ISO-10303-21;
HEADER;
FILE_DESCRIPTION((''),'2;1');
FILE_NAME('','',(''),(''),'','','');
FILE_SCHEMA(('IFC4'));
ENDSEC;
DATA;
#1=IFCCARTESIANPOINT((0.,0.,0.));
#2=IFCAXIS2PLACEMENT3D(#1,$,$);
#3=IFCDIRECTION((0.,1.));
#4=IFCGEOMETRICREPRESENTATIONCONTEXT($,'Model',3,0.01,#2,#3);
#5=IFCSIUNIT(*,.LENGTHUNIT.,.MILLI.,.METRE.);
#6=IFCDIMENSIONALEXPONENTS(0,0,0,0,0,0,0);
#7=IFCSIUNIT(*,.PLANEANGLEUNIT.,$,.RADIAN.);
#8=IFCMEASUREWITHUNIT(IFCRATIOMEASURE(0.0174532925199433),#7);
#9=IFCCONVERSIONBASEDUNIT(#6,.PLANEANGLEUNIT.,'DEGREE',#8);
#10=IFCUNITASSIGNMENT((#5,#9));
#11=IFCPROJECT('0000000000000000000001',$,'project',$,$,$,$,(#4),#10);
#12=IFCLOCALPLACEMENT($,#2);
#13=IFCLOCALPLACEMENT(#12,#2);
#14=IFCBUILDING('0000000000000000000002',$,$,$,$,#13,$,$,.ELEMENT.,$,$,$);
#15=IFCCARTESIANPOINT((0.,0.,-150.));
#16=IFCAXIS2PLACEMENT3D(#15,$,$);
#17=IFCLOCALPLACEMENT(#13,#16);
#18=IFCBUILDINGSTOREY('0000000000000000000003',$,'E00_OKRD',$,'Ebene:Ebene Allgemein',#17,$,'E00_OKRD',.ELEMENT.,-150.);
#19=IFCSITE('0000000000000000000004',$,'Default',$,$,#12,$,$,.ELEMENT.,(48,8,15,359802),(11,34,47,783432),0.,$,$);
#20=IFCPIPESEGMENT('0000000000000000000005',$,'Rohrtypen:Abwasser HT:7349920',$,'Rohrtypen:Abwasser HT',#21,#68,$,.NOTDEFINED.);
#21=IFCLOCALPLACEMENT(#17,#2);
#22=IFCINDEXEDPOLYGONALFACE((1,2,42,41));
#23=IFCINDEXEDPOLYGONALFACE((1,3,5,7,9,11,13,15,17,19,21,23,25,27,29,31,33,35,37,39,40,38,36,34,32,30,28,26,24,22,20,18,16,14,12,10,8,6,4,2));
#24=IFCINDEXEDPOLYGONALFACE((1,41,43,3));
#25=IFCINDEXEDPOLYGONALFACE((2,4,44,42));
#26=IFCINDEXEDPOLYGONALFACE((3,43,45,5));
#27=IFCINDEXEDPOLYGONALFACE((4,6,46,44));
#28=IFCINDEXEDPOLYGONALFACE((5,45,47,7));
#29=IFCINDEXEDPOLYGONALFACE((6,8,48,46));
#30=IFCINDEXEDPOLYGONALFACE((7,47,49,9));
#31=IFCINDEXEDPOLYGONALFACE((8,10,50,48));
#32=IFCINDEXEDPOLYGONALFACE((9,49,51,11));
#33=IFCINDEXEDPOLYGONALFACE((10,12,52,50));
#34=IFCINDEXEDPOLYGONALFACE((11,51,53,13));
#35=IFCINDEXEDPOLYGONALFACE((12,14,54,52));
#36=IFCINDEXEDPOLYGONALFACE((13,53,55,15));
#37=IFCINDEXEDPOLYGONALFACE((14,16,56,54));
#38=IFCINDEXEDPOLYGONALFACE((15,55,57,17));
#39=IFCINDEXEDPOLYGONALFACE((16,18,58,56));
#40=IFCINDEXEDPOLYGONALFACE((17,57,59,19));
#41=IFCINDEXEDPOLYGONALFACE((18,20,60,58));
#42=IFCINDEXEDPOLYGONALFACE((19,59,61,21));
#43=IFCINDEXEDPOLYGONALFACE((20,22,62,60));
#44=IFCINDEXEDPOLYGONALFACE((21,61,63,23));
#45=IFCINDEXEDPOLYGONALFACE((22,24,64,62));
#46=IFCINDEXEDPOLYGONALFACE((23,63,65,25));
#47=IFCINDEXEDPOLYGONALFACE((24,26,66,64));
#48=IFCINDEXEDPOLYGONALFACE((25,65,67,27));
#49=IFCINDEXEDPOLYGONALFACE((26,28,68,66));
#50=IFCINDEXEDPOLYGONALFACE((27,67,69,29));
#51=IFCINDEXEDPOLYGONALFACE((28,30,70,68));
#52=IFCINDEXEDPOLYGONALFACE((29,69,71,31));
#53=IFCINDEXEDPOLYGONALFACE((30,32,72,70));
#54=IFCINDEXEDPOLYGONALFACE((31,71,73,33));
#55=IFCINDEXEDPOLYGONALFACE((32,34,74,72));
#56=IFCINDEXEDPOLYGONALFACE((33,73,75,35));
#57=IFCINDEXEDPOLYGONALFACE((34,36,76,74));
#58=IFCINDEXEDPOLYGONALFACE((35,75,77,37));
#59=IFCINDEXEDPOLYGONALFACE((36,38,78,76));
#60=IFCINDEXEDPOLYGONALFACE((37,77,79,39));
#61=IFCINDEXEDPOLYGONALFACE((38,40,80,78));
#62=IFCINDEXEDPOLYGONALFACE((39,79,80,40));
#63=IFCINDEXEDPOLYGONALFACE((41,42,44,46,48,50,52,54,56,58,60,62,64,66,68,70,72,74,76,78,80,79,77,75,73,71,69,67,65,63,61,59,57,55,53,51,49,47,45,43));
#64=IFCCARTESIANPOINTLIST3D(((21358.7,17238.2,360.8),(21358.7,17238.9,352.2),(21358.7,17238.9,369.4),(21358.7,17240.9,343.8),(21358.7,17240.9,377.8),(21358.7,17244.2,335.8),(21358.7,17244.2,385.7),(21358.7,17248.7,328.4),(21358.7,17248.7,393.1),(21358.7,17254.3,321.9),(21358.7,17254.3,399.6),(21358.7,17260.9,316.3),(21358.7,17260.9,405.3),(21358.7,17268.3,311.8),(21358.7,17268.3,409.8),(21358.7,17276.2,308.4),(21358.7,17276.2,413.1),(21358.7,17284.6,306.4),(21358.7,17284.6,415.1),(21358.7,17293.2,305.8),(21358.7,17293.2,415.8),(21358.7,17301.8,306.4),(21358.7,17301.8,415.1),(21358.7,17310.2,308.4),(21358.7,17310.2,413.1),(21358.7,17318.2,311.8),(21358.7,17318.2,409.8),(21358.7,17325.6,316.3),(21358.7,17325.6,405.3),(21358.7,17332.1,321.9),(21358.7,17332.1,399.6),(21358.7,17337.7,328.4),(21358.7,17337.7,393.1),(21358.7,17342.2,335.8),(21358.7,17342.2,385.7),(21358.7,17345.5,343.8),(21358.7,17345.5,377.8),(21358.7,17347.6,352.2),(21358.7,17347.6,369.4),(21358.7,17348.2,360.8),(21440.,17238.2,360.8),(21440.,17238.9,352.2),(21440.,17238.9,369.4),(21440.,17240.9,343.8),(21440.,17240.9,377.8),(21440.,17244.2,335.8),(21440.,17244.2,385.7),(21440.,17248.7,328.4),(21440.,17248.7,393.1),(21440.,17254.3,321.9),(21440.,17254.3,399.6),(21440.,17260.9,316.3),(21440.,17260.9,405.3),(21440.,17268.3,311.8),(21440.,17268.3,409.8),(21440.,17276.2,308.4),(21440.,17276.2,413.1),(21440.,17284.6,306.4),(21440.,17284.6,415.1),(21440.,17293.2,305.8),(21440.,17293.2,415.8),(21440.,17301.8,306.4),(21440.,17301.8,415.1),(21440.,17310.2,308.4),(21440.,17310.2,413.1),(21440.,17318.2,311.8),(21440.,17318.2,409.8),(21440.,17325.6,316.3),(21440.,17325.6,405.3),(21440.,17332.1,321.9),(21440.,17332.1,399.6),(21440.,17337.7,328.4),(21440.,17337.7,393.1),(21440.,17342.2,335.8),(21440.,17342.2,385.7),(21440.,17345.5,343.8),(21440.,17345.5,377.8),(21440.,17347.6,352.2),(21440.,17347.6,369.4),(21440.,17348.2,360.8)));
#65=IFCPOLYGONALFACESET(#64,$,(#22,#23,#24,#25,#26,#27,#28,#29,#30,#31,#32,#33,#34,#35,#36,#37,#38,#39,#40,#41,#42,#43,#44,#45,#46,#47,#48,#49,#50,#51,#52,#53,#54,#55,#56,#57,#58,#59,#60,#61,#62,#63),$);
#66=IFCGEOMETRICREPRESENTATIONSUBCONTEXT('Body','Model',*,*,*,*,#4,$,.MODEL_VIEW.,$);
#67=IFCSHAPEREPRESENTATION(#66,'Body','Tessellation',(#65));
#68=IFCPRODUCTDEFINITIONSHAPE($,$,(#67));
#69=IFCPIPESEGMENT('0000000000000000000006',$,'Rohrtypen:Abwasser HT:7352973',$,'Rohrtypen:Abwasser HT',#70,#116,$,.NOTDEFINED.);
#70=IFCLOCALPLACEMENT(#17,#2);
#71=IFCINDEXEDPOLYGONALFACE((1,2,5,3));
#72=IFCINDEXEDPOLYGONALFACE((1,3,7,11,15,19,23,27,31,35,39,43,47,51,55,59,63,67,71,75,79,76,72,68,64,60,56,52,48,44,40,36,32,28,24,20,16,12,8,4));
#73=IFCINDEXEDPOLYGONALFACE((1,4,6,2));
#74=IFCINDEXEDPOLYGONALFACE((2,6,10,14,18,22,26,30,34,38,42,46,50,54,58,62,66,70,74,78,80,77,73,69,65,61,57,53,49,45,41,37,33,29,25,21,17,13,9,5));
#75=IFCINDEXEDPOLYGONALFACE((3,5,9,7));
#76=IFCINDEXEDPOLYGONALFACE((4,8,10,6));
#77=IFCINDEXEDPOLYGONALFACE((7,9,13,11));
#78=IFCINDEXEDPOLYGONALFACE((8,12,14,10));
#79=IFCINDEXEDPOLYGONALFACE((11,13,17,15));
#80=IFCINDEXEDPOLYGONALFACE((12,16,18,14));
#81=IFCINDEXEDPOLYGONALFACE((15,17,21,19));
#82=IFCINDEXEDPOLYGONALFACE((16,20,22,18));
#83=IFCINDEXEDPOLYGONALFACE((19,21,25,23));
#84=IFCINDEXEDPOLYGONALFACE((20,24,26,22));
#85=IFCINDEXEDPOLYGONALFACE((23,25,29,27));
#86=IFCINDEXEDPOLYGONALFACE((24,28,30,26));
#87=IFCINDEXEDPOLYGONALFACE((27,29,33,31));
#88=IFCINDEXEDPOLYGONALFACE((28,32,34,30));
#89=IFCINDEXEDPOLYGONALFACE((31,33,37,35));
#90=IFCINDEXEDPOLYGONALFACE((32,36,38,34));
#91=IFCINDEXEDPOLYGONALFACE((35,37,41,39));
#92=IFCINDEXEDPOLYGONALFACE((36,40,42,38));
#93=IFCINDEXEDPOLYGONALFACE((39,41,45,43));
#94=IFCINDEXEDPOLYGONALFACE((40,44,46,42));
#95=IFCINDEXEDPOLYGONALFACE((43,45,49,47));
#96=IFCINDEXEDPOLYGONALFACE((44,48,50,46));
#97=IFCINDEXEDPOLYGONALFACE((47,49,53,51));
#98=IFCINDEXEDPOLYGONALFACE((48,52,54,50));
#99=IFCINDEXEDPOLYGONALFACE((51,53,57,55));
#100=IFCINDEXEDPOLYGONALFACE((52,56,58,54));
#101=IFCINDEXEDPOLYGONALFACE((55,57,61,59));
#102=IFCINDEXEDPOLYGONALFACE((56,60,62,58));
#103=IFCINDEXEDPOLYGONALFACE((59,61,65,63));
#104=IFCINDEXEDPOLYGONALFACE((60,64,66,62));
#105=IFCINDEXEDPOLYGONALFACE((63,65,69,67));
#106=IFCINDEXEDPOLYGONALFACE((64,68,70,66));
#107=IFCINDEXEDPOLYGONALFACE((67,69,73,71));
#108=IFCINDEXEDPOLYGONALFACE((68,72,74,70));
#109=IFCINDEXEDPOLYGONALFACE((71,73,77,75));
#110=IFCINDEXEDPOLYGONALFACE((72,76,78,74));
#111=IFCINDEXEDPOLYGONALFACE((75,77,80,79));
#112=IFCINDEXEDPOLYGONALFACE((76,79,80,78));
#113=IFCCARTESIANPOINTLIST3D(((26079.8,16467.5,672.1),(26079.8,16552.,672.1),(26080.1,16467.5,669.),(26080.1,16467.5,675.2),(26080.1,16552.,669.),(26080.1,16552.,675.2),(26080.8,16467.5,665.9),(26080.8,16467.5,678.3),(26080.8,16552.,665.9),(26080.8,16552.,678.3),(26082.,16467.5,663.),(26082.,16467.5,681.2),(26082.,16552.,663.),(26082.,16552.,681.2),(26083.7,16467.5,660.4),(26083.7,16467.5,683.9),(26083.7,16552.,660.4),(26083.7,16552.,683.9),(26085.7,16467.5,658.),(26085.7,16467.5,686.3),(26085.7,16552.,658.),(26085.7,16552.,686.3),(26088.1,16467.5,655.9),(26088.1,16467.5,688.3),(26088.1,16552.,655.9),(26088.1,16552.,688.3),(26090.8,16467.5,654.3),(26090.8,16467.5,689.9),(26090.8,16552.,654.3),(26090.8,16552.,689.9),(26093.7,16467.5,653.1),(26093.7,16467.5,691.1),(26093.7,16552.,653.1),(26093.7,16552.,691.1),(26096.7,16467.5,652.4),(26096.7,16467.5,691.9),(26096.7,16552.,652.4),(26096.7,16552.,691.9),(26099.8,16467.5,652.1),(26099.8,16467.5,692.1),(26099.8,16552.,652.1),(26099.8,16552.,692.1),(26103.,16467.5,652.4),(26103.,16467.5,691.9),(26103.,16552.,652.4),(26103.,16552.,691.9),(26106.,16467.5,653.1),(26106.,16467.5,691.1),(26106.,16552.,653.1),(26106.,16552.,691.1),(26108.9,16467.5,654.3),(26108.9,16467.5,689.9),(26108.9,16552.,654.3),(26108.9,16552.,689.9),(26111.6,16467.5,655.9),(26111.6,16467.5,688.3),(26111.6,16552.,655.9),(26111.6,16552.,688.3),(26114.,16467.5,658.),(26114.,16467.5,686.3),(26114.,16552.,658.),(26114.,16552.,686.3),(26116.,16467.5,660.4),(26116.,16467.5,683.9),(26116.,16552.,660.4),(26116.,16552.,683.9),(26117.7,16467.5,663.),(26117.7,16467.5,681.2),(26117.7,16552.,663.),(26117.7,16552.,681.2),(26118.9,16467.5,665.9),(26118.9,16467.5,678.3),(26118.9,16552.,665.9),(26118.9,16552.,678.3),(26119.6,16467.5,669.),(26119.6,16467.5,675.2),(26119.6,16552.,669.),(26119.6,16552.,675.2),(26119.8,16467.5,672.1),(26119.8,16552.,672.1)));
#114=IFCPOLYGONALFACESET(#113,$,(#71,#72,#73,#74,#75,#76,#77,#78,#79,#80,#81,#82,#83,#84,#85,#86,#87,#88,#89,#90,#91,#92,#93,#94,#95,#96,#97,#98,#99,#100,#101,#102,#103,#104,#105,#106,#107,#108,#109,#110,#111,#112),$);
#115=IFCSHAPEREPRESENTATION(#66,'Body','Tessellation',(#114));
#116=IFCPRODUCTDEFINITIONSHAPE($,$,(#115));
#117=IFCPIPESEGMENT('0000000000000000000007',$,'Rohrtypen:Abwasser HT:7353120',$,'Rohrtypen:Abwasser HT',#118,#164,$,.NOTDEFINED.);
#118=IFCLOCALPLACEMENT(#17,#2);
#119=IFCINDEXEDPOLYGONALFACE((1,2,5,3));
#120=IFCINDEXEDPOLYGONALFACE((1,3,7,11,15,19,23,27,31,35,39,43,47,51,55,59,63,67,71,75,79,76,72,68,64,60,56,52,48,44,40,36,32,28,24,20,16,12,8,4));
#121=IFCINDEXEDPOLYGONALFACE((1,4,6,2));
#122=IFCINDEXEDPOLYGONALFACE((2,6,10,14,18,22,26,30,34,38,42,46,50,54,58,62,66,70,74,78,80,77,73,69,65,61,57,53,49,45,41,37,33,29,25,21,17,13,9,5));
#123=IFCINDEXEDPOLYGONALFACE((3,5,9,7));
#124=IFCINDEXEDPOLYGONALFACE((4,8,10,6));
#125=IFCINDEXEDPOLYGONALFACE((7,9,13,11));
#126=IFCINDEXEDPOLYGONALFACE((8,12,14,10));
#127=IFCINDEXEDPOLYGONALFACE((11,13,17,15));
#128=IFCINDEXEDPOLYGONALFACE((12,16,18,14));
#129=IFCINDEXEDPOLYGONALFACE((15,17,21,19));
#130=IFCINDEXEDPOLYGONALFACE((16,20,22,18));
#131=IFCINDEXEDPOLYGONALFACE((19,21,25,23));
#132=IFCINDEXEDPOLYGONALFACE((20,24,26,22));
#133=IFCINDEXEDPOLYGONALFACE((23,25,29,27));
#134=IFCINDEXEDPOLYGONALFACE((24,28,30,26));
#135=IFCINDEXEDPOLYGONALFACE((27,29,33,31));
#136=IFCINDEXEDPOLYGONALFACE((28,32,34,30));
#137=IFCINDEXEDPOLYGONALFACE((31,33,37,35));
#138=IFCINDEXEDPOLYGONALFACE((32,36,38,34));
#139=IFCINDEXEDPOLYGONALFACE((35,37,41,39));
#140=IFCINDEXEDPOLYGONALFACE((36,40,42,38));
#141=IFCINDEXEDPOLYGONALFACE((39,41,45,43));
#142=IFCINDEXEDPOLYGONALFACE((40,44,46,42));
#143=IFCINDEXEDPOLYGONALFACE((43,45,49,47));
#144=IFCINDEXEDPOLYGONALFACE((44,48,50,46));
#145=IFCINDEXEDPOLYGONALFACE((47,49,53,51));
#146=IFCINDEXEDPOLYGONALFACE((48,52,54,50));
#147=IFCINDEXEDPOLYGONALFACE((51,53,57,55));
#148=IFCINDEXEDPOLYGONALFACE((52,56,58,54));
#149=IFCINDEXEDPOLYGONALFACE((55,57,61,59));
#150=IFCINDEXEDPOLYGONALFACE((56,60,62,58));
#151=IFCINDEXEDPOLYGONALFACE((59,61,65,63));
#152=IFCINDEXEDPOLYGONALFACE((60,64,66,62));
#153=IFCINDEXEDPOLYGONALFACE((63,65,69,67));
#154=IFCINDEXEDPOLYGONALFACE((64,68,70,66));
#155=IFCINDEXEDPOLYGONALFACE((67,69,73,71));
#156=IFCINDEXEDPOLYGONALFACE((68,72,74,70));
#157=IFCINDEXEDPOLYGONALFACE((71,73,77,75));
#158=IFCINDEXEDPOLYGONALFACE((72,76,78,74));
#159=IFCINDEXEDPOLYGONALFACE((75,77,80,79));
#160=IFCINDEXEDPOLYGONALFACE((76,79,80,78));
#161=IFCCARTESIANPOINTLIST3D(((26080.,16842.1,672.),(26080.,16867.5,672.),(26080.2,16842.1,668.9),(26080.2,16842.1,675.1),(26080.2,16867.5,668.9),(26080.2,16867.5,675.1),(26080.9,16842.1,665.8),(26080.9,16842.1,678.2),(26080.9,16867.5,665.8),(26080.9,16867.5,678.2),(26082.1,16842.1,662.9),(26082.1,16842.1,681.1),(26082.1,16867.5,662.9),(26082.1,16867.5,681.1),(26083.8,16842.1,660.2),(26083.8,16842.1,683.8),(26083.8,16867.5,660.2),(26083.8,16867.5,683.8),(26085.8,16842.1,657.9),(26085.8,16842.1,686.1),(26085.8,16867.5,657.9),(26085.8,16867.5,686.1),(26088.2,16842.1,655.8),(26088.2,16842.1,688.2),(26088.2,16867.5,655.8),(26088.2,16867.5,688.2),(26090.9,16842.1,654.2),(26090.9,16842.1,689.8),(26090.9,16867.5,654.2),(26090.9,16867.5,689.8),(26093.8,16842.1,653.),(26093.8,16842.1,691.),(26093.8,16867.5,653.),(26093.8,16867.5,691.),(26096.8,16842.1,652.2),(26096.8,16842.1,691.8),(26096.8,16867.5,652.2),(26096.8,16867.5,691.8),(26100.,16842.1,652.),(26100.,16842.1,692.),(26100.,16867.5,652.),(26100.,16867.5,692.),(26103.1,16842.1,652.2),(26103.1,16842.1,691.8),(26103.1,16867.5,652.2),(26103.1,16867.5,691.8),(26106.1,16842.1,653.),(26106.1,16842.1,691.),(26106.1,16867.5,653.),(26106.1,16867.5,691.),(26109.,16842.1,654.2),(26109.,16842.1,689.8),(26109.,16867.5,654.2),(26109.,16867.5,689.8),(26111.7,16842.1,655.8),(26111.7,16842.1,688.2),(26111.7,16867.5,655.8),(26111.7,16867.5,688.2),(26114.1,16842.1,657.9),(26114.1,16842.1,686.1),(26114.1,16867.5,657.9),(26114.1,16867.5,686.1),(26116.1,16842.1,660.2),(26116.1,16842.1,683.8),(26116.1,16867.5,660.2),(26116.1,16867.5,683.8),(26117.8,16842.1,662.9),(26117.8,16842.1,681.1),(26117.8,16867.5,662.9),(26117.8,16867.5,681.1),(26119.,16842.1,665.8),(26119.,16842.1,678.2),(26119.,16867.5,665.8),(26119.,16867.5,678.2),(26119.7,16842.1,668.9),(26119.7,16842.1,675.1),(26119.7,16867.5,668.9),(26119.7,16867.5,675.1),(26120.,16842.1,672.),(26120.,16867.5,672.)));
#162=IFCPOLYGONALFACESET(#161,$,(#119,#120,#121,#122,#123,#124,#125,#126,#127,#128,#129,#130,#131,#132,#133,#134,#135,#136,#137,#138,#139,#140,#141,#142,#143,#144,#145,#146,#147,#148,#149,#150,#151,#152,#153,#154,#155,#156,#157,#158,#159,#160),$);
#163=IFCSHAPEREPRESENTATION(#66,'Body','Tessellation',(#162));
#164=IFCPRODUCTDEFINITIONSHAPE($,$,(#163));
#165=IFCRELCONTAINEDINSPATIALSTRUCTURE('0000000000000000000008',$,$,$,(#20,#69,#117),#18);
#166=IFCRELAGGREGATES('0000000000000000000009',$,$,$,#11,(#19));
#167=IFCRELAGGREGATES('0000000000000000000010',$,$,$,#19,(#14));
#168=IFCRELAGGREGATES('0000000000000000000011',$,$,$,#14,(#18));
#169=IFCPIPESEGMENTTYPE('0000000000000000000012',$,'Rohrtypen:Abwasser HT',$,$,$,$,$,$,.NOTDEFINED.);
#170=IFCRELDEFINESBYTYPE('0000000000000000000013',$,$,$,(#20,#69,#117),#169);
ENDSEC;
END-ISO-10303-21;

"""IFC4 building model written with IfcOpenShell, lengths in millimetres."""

from ifc_helpers import new_model, entity, si_unit, converted_unit, direction, frame, origin, place, context, subcontext, project, spatial, indexed_curve, outline, extrude, type_object, element, save


model = new_model("IFC4")

# Units and contexts
model_context = context("Model", 3, precision=0.01, world=origin(), true_north=direction((0.0, 1.0)))
body_context = subcontext(model_context, "Body", "Model", "MODEL_VIEW")
ifc_project = project(units=[si_unit("LENGTHUNIT", "METRE", prefix="MILLI"), converted_unit("PLANEANGLEUNIT", "DEGREE", entity("IfcRatioMeasure", 0.0174532925199433), si_unit("PLANEANGLEUNIT", "RADIAN"), dimensions=[0, 0, 0, 0, 0, 0, 0])], contexts=[model_context])

# Site, building, storey
site_placement = place(None, origin())
site = spatial("IfcSite", under=ifc_project, at=site_placement, Name="Default", CompositionType="ELEMENT", RefLatitude=(48, 8, 15, 359802), RefLongitude=(11, 34, 47, 783432), RefElevation=0.0)
building_placement = place(site_placement, origin())
building = spatial("IfcBuilding", under=site, at=building_placement, CompositionType="ELEMENT")
storey_placement = place(building_placement, frame((0.0, 0.0, -150.0)))
storey = spatial("IfcBuildingStorey", under=building, at=storey_placement, Name="E00_OKRD", ObjectType="Ebene:Ebene Allgemein", LongName="E00_OKRD", CompositionType="ELEMENT", Elevation=-150.0)

# Pipe segments
pipe_segment_type_1 = type_object("IfcPipeSegmentType", Name="Rohrtypen:Abwasser HT", PredefinedType="NOTDEFINED")
pipe_segment_1_placement = place(storey_placement, origin())
element("IfcPipeSegment", 1, at=pipe_segment_1_placement, inside=storey, type_object=pipe_segment_type_1, Name="Rohrtypen:Abwasser HT:7349920", ObjectType="Rohrtypen:Abwasser HT", PredefinedType="NOTDEFINED", context=body_context, shape_type="SweptSolid", body=[
    extrude(outline(indexed_curve([(55.0, 0.0), (54.3, 8.6), (52.3, 17.0), (49.0, 25.0), (44.5, 32.3), (38.9, 38.9), (32.3, 44.5), (25.0, 49.0), (17.0, 52.3), (8.6, 54.3), (0.0, 55.0), (-8.6, 54.3), (-17.0, 52.3), (-25.0, 49.0), (-32.3, 44.5), (-38.9, 38.9), (-44.5, 32.3), (-49.0, 25.0), (-52.3, 17.0), (-54.3, 8.6), (-55.0, 0.0), (-54.3, -8.6), (-52.3, -17.0), (-49.0, -25.0), (-44.5, -32.3), (-38.9, -38.9), (-32.3, -44.5), (-25.0, -49.0), (-17.0, -52.3), (-8.6, -54.3), (0.0, -55.0), (8.6, -54.3), (17.0, -52.3), (25.0, -49.0), (32.3, -44.5), (38.9, -38.9), (44.5, -32.3), (49.0, -25.0), (52.3, -17.0), (54.3, -8.6), (55.0, 0.0)], self_intersect=False)), frame((21358.7, 17293.2, 360.8), z_axis=(1.0, 0.0, 0.0), x_axis=(0.0, 1.0, 0.0)), (0.0, 0.0, 1.0), 81.3),
])
pipe_segment_2_placement = place(storey_placement, origin())
element("IfcPipeSegment", 2, at=pipe_segment_2_placement, inside=storey, type_object=pipe_segment_type_1, Name="Rohrtypen:Abwasser HT:7352973", ObjectType="Rohrtypen:Abwasser HT", PredefinedType="NOTDEFINED", context=body_context, shape_type="SweptSolid", body=[
    extrude(outline(indexed_curve([(20.0, 0.0), (19.8, 3.1), (19.0, 6.2), (17.8, 9.1), (16.2, 11.8), (14.1, 14.1), (11.8, 16.2), (9.1, 17.8), (6.2, 19.0), (3.1, 19.8), (0.0, 20.0), (-3.1, 19.8), (-6.2, 19.0), (-9.1, 17.8), (-11.8, 16.2), (-14.1, 14.1), (-16.2, 11.8), (-17.8, 9.1), (-19.0, 6.2), (-19.8, 3.1), (-20.0, 0.0), (-19.8, -3.1), (-19.0, -6.2), (-17.8, -9.1), (-16.2, -11.8), (-14.1, -14.1), (-11.8, -16.2), (-9.1, -17.8), (-6.2, -19.0), (-3.1, -19.8), (0.0, -20.0), (3.1, -19.8), (6.2, -19.0), (9.1, -17.8), (11.8, -16.2), (14.1, -14.1), (16.2, -11.8), (17.8, -9.1), (19.0, -6.2), (19.8, -3.1), (20.0, 0.0)], self_intersect=False)), frame((26099.8, 16467.5, 672.1), z_axis=(0.0, 1.0, 0.0), x_axis=(1.0, 0.0, 0.0)), (0.0, 0.0, 1.0), 84.4),
])
pipe_segment_3_placement = place(storey_placement, origin())
element("IfcPipeSegment", 3, at=pipe_segment_3_placement, inside=storey, type_object=pipe_segment_type_1, Name="Rohrtypen:Abwasser HT:7353120", ObjectType="Rohrtypen:Abwasser HT", PredefinedType="NOTDEFINED", context=body_context, shape_type="SweptSolid", body=[
    extrude(outline(indexed_curve([(20.0, 0.0), (19.8, 3.1), (19.0, 6.2), (17.8, 9.1), (16.2, 11.8), (14.1, 14.1), (11.8, 16.2), (9.1, 17.8), (6.2, 19.0), (3.1, 19.8), (0.0, 20.0), (-3.1, 19.8), (-6.2, 19.0), (-9.1, 17.8), (-11.8, 16.2), (-14.1, 14.1), (-16.2, 11.8), (-17.8, 9.1), (-19.0, 6.2), (-19.8, 3.1), (-20.0, 0.0), (-19.8, -3.1), (-19.0, -6.2), (-17.8, -9.1), (-16.2, -11.8), (-14.1, -14.1), (-11.8, -16.2), (-9.1, -17.8), (-6.2, -19.0), (-3.1, -19.8), (0.0, -20.0), (3.1, -19.8), (6.2, -19.0), (9.1, -17.8), (11.8, -16.2), (14.1, -14.1), (16.2, -11.8), (17.8, -9.1), (19.0, -6.2), (19.8, -3.1), (20.0, 0.0)], self_intersect=False)), frame((26100.0, 16842.1, 672.0), z_axis=(0.0, 1.0, 0.0), x_axis=(-1.0, 0.0, 0.0)), (0.0, 0.0, 1.0), 25.5),
])

save(model, "model.ifc")
